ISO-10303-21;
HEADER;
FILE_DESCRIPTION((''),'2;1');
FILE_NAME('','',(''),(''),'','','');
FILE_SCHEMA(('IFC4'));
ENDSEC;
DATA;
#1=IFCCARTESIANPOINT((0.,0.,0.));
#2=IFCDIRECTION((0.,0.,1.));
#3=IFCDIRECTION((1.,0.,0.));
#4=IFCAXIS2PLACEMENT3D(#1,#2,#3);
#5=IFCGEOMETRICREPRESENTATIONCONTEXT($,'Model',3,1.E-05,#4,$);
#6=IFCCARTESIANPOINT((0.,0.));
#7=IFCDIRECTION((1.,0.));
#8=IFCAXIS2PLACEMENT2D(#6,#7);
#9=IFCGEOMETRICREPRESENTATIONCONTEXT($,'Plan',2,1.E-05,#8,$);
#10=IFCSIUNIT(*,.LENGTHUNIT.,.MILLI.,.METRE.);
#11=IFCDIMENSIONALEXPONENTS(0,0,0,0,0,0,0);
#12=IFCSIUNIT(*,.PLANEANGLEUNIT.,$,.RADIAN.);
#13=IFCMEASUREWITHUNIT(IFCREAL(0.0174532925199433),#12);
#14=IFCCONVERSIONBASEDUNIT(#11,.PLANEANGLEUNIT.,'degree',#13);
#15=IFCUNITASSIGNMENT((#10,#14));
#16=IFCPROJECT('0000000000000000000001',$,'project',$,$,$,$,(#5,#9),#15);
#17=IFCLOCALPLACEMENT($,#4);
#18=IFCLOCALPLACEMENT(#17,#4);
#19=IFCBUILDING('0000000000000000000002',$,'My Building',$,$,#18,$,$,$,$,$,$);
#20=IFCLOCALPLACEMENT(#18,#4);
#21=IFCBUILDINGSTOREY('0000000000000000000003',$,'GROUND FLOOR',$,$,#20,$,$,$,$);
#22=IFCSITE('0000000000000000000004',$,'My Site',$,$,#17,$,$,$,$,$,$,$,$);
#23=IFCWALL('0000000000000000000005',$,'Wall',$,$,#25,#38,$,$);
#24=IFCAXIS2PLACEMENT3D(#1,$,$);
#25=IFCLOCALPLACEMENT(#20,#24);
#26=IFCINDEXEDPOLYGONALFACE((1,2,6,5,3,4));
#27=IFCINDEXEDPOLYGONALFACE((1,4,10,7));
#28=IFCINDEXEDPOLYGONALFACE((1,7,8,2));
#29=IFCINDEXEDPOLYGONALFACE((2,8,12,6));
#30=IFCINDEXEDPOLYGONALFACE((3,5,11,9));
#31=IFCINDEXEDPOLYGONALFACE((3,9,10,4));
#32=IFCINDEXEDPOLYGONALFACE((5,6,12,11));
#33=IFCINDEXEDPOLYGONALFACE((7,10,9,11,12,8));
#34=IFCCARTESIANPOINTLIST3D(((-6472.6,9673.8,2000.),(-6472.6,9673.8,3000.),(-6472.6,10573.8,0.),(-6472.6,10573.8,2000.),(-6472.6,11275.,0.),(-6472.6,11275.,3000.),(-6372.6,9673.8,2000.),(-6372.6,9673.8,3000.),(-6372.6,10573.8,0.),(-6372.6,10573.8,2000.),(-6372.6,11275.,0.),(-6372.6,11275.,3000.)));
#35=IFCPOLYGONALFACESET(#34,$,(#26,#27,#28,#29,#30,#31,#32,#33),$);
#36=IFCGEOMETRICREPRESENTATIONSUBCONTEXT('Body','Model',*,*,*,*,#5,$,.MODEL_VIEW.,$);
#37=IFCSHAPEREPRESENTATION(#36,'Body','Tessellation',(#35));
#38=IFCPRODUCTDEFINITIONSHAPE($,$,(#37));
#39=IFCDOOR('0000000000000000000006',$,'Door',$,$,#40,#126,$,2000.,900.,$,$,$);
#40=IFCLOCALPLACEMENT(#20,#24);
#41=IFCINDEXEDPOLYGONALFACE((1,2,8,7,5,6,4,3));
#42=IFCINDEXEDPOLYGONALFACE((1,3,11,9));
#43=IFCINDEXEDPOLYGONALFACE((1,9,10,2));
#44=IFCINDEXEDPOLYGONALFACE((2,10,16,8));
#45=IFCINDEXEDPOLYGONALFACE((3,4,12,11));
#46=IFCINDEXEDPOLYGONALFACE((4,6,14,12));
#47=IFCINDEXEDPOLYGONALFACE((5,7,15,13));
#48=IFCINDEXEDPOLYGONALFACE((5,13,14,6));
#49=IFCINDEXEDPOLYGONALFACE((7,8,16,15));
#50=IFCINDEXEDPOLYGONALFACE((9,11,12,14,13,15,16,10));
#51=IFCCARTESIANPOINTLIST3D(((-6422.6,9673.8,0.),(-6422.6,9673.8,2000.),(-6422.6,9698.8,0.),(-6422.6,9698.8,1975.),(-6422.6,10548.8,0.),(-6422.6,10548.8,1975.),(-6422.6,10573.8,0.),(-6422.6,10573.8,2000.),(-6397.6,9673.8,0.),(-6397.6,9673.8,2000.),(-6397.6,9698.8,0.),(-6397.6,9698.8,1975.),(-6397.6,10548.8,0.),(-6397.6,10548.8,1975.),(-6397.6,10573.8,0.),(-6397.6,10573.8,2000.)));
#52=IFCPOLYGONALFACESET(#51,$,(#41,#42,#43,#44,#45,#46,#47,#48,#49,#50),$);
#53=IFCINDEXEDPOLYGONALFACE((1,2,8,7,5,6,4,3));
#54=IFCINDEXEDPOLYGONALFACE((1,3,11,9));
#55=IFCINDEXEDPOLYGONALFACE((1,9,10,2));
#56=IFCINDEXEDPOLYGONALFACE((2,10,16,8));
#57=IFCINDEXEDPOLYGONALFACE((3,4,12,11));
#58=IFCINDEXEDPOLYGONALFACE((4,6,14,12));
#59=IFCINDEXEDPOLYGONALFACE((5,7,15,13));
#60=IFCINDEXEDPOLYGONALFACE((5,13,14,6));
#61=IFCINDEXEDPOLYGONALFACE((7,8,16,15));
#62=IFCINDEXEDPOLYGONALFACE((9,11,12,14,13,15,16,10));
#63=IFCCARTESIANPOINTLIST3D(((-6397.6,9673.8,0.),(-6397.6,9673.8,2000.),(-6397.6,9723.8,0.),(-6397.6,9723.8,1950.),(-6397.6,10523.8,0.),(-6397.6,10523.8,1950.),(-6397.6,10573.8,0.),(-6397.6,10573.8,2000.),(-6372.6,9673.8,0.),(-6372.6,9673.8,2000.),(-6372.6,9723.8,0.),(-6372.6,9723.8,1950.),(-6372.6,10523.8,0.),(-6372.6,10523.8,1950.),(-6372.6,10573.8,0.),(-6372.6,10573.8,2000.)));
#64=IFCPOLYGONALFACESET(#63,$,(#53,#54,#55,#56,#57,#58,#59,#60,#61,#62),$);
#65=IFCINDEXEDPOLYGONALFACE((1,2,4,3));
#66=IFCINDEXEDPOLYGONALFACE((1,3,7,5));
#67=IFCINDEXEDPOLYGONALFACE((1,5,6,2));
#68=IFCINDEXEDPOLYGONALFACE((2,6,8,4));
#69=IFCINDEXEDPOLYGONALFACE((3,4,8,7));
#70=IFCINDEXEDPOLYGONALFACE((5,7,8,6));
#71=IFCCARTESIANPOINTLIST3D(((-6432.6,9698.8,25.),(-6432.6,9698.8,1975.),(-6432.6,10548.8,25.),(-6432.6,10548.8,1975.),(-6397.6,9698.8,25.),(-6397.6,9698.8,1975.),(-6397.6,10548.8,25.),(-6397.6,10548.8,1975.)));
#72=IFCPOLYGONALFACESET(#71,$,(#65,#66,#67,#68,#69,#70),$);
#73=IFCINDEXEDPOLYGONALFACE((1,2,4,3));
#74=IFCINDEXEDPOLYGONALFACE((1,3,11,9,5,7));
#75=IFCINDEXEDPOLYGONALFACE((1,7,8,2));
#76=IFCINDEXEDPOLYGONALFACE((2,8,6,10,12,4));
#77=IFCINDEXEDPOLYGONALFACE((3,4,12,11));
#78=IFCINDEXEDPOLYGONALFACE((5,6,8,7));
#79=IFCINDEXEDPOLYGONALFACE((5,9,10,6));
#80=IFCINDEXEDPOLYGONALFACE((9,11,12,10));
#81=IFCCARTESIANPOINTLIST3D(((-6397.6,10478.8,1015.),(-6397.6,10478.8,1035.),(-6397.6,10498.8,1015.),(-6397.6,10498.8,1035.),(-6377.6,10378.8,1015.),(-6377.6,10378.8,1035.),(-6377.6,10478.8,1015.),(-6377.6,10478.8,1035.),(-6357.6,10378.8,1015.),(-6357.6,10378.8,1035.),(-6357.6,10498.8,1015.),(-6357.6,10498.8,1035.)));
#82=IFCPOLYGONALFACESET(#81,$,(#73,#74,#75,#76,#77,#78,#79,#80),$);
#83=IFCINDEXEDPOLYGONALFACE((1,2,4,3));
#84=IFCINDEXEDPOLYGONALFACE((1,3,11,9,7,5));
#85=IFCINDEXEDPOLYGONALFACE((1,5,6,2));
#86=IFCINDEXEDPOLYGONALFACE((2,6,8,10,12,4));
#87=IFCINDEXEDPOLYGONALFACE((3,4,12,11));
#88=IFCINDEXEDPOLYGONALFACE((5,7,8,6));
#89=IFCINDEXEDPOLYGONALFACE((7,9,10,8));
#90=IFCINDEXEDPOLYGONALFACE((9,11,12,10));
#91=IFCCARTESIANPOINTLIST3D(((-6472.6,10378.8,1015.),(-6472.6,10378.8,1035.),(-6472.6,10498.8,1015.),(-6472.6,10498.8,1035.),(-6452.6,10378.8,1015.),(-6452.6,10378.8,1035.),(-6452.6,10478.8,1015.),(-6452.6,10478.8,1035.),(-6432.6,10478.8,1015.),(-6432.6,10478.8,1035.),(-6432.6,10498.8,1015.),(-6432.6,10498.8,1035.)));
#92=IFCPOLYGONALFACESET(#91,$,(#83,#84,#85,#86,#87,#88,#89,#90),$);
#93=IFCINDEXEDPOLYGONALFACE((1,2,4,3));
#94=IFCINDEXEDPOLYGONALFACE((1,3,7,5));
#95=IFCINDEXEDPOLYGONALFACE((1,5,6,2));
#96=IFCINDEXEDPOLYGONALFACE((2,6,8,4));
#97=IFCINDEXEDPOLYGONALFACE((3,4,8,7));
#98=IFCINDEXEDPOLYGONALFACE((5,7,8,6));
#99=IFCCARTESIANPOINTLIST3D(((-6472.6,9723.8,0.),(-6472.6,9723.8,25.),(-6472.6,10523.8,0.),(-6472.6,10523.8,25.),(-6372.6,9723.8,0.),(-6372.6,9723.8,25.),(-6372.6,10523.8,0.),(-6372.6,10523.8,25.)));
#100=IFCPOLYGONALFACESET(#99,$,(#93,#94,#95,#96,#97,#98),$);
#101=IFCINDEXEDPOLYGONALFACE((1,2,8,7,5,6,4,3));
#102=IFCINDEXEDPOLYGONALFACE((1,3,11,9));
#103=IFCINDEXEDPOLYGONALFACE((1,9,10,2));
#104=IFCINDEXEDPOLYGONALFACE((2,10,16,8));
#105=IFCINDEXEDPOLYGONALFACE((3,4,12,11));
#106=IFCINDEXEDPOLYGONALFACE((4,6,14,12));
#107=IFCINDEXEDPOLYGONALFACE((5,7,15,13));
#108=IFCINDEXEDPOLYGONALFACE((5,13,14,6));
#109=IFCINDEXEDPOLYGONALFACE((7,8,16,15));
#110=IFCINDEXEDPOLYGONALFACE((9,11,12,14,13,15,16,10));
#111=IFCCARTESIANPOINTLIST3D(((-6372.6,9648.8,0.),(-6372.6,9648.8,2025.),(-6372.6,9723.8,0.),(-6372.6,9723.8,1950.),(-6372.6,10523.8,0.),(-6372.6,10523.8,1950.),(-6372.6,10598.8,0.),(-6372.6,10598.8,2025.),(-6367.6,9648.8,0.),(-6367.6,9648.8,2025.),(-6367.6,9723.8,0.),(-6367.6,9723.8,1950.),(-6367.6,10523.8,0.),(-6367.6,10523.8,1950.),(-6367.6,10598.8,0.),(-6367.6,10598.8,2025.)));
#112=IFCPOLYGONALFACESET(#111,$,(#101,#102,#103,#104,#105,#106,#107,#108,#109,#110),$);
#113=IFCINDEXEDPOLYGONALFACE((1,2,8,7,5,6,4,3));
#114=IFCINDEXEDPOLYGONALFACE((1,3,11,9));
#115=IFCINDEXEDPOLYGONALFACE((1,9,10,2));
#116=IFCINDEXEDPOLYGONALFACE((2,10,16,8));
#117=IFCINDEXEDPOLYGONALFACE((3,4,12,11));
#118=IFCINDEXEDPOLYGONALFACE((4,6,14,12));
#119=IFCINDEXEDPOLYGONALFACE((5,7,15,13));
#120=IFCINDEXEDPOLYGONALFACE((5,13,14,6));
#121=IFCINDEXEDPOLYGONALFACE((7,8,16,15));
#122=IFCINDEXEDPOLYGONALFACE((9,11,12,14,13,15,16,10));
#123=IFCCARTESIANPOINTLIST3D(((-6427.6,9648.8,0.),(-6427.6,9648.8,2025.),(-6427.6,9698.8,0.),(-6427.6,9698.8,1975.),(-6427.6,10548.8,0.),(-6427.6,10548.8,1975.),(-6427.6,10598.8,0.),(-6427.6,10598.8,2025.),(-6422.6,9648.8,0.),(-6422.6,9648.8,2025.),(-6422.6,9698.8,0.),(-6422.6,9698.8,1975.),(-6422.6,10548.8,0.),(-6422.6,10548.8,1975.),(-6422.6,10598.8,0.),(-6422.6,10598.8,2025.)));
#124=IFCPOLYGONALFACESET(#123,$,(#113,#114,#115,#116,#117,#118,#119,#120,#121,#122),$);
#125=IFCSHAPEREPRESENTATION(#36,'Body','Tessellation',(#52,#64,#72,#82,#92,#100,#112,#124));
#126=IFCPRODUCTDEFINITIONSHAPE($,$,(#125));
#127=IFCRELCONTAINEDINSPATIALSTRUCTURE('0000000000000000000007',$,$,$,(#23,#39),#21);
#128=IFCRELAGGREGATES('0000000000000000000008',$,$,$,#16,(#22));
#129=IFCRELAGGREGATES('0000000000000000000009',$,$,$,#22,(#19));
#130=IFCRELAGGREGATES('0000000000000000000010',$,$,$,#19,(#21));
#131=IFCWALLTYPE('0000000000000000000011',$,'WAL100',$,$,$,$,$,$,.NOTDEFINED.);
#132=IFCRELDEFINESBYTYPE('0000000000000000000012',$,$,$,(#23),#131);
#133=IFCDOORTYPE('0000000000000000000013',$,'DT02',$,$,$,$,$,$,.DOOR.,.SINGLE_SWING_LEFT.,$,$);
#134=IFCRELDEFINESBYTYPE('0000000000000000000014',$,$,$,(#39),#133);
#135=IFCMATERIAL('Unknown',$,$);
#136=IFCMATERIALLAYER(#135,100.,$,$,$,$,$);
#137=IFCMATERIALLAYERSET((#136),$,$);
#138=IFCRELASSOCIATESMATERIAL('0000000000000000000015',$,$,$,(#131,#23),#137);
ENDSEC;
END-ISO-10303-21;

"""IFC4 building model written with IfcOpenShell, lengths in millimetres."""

from ifc_helpers import new_model, entity, si_unit, converted_unit, frame, origin_with_axes, origin_2d_with_axis, place, context, subcontext, project, spatial, line, indexed_curve, outline, extrude, shape, source, transform, mapped, material, layer, layer_set, layer_usage, type_object, type_shapes, element, fill, save


model = new_model("IFC4")

# Units and contexts
model_context = context("Model", 3, precision=1e-05, world=origin_with_axes())
plan_context = context("Plan", 2, precision=1e-05, world=origin_2d_with_axis())
body_context_1 = subcontext(model_context, "Body", "Model", "MODEL_VIEW")
body_context_2 = subcontext(plan_context, "Body", "Plan", "PLAN_VIEW")
ifc_project = project(units=[si_unit("LENGTHUNIT", "METRE", prefix="MILLI"), converted_unit("PLANEANGLEUNIT", "degree", entity("IfcReal", 0.0174532925199433), si_unit("PLANEANGLEUNIT", "RADIAN"), dimensions=[0, 0, 0, 0, 0, 0, 0])], contexts=[model_context, plan_context])

# Site, building, storey
site_placement = place(None, origin_with_axes())
site = spatial("IfcSite", under=ifc_project, at=site_placement, Name="My Site")
building_placement = place(site_placement, origin_with_axes())
building = spatial("IfcBuilding", under=site, at=building_placement, Name="My Building")
storey_placement = place(building_placement, origin_with_axes())
storey = spatial("IfcBuildingStorey", under=building, at=storey_placement, Name="GROUND FLOOR")

# Shared definitions
ifc_material_1 = material(Name="Unknown")
ifc_layer_1 = layer(ifc_material_1, 100.0)
ifc_layer_set_1 = layer_set([ifc_layer_1])
wall_type_1 = type_object("IfcWallType", Name="WAL100", PredefinedType="NOTDEFINED", material=ifc_layer_set_1)

# Wall, opening, door
ifc_layer_usage_1 = layer_usage(ifc_layer_set_1, "AXIS2", "POSITIVE", 0.0)
wall_1_placement = place(storey_placement, frame((-6372.6, 9673.8, 0.0), z_axis=(0.0, 0.0, 1.0), x_axis=(0.000001, 1.0, 0.0)))
wall_1 = element("IfcWall", 1, at=wall_1_placement, inside=storey, type_object=wall_type_1, material=ifc_layer_usage_1, Name="Wall", context=body_context_1, shape_type="SweptSolid", body=[
    extrude(outline(indexed_curve([(0.0, 0.0), (0.0, 100.0), (1601.2, 100.0), (1601.2, 0.0), (0.0, 0.0)], self_intersect=False)), origin_with_axes(), (0.0, 0.0, 1.0), 3000.0),
])
shared_shape_1 = source(origin_with_axes(), body_context_1, "Body", "SweptSolid", [
    extrude(outline(indexed_curve([(0.0, 0.0), (900.0, 0.0), (900.0, 2000.0), (0.0, 2000.0)], segments=[line(1, 2), line(2, 3), line(3, 4), line(4, 1)])), frame((0.0, -100.0, 0.0), z_axis=(0.0, -1.0, 0.0), x_axis=(1.0, 0.0, 0.0)), (0.0, 0.0, -1.0), 300.0),
])
opening_1_placement = place(wall_1_placement, origin_with_axes())
opening_1 = element("IfcOpeningElement", 2, at=opening_1_placement, cuts=wall_1, PredefinedType="OPENING", context=body_context_1, shape_type="MappedRepresentation", body=[
    mapped(shared_shape_1, transform((0.0, 0.0, 0.0), x_axis=(1.0, 0.0, 0.0), y_axis=(0.0, 1.0, 0.0), z_axis=(0.0, 0.0, 1.0), scale=1.0)),
])
door_type = type_object("IfcDoorType", Name="DT02", OperationType="SINGLE_SWING_LEFT", PredefinedType="DOOR")
shared_shape_2 = source(origin_with_axes(), body_context_1, "Body", "SweptSolid", [
    extrude(outline(indexed_curve([(0.0, 0.0), (0.0, 2000.0), (900.0, 2000.0), (900.0, 0.0), (875.0, 0.0), (875.0, 1975.0), (25.0, 1975.0), (25.0, 0.0)], segments=[line(1, 2), line(2, 3), line(3, 4), line(4, 5), line(5, 6), line(6, 7), line(7, 8), line(8, 1)])), frame((0.0, 25.0, 0.0), z_axis=(0.0, -1.0, 0.0), x_axis=(1.0, 0.0, 0.0)), (0.0, 0.0, -1.0), 25.0),
    extrude(outline(indexed_curve([(0.0, 0.0), (0.0, 2000.0), (900.0, 2000.0), (900.0, 0.0), (850.0, 0.0), (850.0, 1950.0), (50.0, 1950.0), (50.0, 0.0)], segments=[line(1, 2), line(2, 3), line(3, 4), line(4, 5), line(5, 6), line(6, 7), line(7, 8), line(8, 1)])), frame((0.0, 0.0, 0.0), z_axis=(0.0, -1.0, 0.0), x_axis=(1.0, 0.0, 0.0)), (0.0, 0.0, -1.0), 25.0),
    extrude(outline(indexed_curve([(0.0, 0.0), (850.0, 0.0), (850.0, 35.0), (0.0, 35.0)], segments=[line(1, 2), line(2, 3), line(3, 4), line(4, 1)])), frame((25.0, 25.0, 25.0), z_axis=(0.0, 0.0, 1.0), x_axis=(1.0, 0.0, 0.0)), (0.0, 0.0, 1.0), 1950.0),
    extrude(outline(indexed_curve([(0.0, 0.0), (0.0, -40.0), (-120.0, -40.0), (-120.0, -20.0), (-20.0, -20.0), (-20.0, 0.0)], segments=[line(1, 2), line(2, 3), line(3, 4), line(4, 5), line(5, 6), line(6, 1)])), frame((825.0, 25.0, 1015.0), z_axis=(0.0, 0.0, 1.0), x_axis=(1.0, 0.0, 0.0)), (0.0, 0.0, 1.0), 20.0),
    extrude(outline(indexed_curve([(0.0, 0.0), (0.0, 40.0), (-120.0, 40.0), (-120.0, 20.0), (-20.0, 20.0), (-20.0, 0.0)], segments=[line(1, 2), line(2, 3), line(3, 4), line(4, 5), line(5, 6), line(6, 1)])), frame((825.0, 60.0, 1015.0), z_axis=(0.0, 0.0, 1.0), x_axis=(1.0, 0.0, 0.0)), (0.0, 0.0, 1.0), 20.0),
    extrude(outline(indexed_curve([(0.0, 0.0), (800.0, 0.0), (800.0, 100.0), (0.0, 100.0)], segments=[line(1, 2), line(2, 3), line(3, 4), line(4, 1)])), frame((50.0, 0.0, 0.0), z_axis=(0.0, 0.0, 1.0), x_axis=(1.0, 0.0, 0.0)), (0.0, 0.0, 1.0), 25.0),
    extrude(outline(indexed_curve([(0.0, 0.0), (0.0, 2025.0), (950.0, 2025.0), (950.0, 0.0), (875.0, 0.0), (875.0, 1950.0), (75.0, 1950.0), (75.0, 0.0)], segments=[line(1, 2), line(2, 3), line(3, 4), line(4, 5), line(5, 6), line(6, 7), line(7, 8), line(8, 1)])), frame((-25.0, -5.0, 0.0), z_axis=(0.0, -1.0, 0.0), x_axis=(1.0, 0.0, 0.0)), (0.0, 0.0, -1.0), 5.0),
    extrude(outline(indexed_curve([(0.0, 0.0), (0.0, 2025.0), (950.0, 2025.0), (950.0, 0.0), (900.0, 0.0), (900.0, 1975.0), (50.0, 1975.0), (50.0, 0.0)], segments=[line(1, 2), line(2, 3), line(3, 4), line(4, 5), line(5, 6), line(6, 7), line(7, 8), line(8, 1)])), frame((-25.0, 50.0, 0.0), z_axis=(0.0, -1.0, 0.0), x_axis=(1.0, 0.0, 0.0)), (0.0, 0.0, -1.0), 5.0),
])
shared_shape_3 = source(origin_with_axes(), body_context_2, "Body", "Curve2D", [
    entity("IfcIndexedPolyCurve", entity("IfcCartesianPointList2D", [[0.0, 0.0], [0.0, 50.0], [25.0, 50.0], [25.0, 25.0], [50.0, 25.0], [50.0, 0.0]]), [entity("IfcLineIndex", [1, 2]), entity("IfcLineIndex", [2, 3]), entity("IfcLineIndex", [3, 4]), entity("IfcLineIndex", [4, 5]), entity("IfcLineIndex", [5, 6]), entity("IfcLineIndex", [6, 1])]),
    entity("IfcIndexedPolyCurve", entity("IfcCartesianPointList2D", [[900.0, 0.0], [900.0, 50.0], [875.0, 50.0], [875.0, 25.0], [850.0, 25.0], [850.0, 0.0]]), [entity("IfcLineIndex", [1, 2]), entity("IfcLineIndex", [2, 3]), entity("IfcLineIndex", [3, 4]), entity("IfcLineIndex", [4, 5]), entity("IfcLineIndex", [5, 6]), entity("IfcLineIndex", [6, 1])]),
    entity("IfcTrimmedCurve", entity("IfcEllipse", entity("IfcAxis2Placement2D", entity("IfcCartesianPoint", [60.0, 50.0]), entity("IfcDirection", [1.0, 0.0])), 815.0, 850.0), [entity("IfcCartesianPoint", [875.0, 50.0])], [entity("IfcCartesianPoint", [60.0, 900.0])], True, "CARTESIAN"),
    entity("IfcIndexedPolyCurve", entity("IfcCartesianPointList2D", [[25.0, 50.0], [60.0, 50.0], [60.0, 900.0], [25.0, 900.0]]), [entity("IfcLineIndex", [1, 2]), entity("IfcLineIndex", [2, 3]), entity("IfcLineIndex", [3, 4]), entity("IfcLineIndex", [4, 1])]),
])
type_shapes(door_type, [shared_shape_2, shared_shape_3])
door_1_placement = place(opening_1_placement, frame((0.0, 0.0, 0.0), z_axis=(0.0, 0.0, 1.0), x_axis=(1.0, 0.0, 0.0)))
door_1 = element("IfcDoor", 3, at=door_1_placement, inside=storey, type_object=door_type, Name="Door", OverallHeight=2000.0, OverallWidth=900.0, shapes=[
    shape(body_context_1, "Body", "MappedRepresentation", [mapped(shared_shape_2, transform((0.0, 0.0, 0.0), x_axis=(1.0, 0.0, 0.0), y_axis=(0.0, 1.0, 0.0), z_axis=(0.0, 0.0, 1.0), scale=1.0))]),
    shape(body_context_2, "Body", "MappedRepresentation", [mapped(shared_shape_3, transform((0.0, 0.0, 0.0), x_axis=(1.0, 0.0, 0.0), y_axis=(0.0, 1.0, 0.0), z_axis=(0.0, 0.0, 1.0), scale=1.0))]),
])
fill(opening_1, door_1)

save(model, "model.ifc")
